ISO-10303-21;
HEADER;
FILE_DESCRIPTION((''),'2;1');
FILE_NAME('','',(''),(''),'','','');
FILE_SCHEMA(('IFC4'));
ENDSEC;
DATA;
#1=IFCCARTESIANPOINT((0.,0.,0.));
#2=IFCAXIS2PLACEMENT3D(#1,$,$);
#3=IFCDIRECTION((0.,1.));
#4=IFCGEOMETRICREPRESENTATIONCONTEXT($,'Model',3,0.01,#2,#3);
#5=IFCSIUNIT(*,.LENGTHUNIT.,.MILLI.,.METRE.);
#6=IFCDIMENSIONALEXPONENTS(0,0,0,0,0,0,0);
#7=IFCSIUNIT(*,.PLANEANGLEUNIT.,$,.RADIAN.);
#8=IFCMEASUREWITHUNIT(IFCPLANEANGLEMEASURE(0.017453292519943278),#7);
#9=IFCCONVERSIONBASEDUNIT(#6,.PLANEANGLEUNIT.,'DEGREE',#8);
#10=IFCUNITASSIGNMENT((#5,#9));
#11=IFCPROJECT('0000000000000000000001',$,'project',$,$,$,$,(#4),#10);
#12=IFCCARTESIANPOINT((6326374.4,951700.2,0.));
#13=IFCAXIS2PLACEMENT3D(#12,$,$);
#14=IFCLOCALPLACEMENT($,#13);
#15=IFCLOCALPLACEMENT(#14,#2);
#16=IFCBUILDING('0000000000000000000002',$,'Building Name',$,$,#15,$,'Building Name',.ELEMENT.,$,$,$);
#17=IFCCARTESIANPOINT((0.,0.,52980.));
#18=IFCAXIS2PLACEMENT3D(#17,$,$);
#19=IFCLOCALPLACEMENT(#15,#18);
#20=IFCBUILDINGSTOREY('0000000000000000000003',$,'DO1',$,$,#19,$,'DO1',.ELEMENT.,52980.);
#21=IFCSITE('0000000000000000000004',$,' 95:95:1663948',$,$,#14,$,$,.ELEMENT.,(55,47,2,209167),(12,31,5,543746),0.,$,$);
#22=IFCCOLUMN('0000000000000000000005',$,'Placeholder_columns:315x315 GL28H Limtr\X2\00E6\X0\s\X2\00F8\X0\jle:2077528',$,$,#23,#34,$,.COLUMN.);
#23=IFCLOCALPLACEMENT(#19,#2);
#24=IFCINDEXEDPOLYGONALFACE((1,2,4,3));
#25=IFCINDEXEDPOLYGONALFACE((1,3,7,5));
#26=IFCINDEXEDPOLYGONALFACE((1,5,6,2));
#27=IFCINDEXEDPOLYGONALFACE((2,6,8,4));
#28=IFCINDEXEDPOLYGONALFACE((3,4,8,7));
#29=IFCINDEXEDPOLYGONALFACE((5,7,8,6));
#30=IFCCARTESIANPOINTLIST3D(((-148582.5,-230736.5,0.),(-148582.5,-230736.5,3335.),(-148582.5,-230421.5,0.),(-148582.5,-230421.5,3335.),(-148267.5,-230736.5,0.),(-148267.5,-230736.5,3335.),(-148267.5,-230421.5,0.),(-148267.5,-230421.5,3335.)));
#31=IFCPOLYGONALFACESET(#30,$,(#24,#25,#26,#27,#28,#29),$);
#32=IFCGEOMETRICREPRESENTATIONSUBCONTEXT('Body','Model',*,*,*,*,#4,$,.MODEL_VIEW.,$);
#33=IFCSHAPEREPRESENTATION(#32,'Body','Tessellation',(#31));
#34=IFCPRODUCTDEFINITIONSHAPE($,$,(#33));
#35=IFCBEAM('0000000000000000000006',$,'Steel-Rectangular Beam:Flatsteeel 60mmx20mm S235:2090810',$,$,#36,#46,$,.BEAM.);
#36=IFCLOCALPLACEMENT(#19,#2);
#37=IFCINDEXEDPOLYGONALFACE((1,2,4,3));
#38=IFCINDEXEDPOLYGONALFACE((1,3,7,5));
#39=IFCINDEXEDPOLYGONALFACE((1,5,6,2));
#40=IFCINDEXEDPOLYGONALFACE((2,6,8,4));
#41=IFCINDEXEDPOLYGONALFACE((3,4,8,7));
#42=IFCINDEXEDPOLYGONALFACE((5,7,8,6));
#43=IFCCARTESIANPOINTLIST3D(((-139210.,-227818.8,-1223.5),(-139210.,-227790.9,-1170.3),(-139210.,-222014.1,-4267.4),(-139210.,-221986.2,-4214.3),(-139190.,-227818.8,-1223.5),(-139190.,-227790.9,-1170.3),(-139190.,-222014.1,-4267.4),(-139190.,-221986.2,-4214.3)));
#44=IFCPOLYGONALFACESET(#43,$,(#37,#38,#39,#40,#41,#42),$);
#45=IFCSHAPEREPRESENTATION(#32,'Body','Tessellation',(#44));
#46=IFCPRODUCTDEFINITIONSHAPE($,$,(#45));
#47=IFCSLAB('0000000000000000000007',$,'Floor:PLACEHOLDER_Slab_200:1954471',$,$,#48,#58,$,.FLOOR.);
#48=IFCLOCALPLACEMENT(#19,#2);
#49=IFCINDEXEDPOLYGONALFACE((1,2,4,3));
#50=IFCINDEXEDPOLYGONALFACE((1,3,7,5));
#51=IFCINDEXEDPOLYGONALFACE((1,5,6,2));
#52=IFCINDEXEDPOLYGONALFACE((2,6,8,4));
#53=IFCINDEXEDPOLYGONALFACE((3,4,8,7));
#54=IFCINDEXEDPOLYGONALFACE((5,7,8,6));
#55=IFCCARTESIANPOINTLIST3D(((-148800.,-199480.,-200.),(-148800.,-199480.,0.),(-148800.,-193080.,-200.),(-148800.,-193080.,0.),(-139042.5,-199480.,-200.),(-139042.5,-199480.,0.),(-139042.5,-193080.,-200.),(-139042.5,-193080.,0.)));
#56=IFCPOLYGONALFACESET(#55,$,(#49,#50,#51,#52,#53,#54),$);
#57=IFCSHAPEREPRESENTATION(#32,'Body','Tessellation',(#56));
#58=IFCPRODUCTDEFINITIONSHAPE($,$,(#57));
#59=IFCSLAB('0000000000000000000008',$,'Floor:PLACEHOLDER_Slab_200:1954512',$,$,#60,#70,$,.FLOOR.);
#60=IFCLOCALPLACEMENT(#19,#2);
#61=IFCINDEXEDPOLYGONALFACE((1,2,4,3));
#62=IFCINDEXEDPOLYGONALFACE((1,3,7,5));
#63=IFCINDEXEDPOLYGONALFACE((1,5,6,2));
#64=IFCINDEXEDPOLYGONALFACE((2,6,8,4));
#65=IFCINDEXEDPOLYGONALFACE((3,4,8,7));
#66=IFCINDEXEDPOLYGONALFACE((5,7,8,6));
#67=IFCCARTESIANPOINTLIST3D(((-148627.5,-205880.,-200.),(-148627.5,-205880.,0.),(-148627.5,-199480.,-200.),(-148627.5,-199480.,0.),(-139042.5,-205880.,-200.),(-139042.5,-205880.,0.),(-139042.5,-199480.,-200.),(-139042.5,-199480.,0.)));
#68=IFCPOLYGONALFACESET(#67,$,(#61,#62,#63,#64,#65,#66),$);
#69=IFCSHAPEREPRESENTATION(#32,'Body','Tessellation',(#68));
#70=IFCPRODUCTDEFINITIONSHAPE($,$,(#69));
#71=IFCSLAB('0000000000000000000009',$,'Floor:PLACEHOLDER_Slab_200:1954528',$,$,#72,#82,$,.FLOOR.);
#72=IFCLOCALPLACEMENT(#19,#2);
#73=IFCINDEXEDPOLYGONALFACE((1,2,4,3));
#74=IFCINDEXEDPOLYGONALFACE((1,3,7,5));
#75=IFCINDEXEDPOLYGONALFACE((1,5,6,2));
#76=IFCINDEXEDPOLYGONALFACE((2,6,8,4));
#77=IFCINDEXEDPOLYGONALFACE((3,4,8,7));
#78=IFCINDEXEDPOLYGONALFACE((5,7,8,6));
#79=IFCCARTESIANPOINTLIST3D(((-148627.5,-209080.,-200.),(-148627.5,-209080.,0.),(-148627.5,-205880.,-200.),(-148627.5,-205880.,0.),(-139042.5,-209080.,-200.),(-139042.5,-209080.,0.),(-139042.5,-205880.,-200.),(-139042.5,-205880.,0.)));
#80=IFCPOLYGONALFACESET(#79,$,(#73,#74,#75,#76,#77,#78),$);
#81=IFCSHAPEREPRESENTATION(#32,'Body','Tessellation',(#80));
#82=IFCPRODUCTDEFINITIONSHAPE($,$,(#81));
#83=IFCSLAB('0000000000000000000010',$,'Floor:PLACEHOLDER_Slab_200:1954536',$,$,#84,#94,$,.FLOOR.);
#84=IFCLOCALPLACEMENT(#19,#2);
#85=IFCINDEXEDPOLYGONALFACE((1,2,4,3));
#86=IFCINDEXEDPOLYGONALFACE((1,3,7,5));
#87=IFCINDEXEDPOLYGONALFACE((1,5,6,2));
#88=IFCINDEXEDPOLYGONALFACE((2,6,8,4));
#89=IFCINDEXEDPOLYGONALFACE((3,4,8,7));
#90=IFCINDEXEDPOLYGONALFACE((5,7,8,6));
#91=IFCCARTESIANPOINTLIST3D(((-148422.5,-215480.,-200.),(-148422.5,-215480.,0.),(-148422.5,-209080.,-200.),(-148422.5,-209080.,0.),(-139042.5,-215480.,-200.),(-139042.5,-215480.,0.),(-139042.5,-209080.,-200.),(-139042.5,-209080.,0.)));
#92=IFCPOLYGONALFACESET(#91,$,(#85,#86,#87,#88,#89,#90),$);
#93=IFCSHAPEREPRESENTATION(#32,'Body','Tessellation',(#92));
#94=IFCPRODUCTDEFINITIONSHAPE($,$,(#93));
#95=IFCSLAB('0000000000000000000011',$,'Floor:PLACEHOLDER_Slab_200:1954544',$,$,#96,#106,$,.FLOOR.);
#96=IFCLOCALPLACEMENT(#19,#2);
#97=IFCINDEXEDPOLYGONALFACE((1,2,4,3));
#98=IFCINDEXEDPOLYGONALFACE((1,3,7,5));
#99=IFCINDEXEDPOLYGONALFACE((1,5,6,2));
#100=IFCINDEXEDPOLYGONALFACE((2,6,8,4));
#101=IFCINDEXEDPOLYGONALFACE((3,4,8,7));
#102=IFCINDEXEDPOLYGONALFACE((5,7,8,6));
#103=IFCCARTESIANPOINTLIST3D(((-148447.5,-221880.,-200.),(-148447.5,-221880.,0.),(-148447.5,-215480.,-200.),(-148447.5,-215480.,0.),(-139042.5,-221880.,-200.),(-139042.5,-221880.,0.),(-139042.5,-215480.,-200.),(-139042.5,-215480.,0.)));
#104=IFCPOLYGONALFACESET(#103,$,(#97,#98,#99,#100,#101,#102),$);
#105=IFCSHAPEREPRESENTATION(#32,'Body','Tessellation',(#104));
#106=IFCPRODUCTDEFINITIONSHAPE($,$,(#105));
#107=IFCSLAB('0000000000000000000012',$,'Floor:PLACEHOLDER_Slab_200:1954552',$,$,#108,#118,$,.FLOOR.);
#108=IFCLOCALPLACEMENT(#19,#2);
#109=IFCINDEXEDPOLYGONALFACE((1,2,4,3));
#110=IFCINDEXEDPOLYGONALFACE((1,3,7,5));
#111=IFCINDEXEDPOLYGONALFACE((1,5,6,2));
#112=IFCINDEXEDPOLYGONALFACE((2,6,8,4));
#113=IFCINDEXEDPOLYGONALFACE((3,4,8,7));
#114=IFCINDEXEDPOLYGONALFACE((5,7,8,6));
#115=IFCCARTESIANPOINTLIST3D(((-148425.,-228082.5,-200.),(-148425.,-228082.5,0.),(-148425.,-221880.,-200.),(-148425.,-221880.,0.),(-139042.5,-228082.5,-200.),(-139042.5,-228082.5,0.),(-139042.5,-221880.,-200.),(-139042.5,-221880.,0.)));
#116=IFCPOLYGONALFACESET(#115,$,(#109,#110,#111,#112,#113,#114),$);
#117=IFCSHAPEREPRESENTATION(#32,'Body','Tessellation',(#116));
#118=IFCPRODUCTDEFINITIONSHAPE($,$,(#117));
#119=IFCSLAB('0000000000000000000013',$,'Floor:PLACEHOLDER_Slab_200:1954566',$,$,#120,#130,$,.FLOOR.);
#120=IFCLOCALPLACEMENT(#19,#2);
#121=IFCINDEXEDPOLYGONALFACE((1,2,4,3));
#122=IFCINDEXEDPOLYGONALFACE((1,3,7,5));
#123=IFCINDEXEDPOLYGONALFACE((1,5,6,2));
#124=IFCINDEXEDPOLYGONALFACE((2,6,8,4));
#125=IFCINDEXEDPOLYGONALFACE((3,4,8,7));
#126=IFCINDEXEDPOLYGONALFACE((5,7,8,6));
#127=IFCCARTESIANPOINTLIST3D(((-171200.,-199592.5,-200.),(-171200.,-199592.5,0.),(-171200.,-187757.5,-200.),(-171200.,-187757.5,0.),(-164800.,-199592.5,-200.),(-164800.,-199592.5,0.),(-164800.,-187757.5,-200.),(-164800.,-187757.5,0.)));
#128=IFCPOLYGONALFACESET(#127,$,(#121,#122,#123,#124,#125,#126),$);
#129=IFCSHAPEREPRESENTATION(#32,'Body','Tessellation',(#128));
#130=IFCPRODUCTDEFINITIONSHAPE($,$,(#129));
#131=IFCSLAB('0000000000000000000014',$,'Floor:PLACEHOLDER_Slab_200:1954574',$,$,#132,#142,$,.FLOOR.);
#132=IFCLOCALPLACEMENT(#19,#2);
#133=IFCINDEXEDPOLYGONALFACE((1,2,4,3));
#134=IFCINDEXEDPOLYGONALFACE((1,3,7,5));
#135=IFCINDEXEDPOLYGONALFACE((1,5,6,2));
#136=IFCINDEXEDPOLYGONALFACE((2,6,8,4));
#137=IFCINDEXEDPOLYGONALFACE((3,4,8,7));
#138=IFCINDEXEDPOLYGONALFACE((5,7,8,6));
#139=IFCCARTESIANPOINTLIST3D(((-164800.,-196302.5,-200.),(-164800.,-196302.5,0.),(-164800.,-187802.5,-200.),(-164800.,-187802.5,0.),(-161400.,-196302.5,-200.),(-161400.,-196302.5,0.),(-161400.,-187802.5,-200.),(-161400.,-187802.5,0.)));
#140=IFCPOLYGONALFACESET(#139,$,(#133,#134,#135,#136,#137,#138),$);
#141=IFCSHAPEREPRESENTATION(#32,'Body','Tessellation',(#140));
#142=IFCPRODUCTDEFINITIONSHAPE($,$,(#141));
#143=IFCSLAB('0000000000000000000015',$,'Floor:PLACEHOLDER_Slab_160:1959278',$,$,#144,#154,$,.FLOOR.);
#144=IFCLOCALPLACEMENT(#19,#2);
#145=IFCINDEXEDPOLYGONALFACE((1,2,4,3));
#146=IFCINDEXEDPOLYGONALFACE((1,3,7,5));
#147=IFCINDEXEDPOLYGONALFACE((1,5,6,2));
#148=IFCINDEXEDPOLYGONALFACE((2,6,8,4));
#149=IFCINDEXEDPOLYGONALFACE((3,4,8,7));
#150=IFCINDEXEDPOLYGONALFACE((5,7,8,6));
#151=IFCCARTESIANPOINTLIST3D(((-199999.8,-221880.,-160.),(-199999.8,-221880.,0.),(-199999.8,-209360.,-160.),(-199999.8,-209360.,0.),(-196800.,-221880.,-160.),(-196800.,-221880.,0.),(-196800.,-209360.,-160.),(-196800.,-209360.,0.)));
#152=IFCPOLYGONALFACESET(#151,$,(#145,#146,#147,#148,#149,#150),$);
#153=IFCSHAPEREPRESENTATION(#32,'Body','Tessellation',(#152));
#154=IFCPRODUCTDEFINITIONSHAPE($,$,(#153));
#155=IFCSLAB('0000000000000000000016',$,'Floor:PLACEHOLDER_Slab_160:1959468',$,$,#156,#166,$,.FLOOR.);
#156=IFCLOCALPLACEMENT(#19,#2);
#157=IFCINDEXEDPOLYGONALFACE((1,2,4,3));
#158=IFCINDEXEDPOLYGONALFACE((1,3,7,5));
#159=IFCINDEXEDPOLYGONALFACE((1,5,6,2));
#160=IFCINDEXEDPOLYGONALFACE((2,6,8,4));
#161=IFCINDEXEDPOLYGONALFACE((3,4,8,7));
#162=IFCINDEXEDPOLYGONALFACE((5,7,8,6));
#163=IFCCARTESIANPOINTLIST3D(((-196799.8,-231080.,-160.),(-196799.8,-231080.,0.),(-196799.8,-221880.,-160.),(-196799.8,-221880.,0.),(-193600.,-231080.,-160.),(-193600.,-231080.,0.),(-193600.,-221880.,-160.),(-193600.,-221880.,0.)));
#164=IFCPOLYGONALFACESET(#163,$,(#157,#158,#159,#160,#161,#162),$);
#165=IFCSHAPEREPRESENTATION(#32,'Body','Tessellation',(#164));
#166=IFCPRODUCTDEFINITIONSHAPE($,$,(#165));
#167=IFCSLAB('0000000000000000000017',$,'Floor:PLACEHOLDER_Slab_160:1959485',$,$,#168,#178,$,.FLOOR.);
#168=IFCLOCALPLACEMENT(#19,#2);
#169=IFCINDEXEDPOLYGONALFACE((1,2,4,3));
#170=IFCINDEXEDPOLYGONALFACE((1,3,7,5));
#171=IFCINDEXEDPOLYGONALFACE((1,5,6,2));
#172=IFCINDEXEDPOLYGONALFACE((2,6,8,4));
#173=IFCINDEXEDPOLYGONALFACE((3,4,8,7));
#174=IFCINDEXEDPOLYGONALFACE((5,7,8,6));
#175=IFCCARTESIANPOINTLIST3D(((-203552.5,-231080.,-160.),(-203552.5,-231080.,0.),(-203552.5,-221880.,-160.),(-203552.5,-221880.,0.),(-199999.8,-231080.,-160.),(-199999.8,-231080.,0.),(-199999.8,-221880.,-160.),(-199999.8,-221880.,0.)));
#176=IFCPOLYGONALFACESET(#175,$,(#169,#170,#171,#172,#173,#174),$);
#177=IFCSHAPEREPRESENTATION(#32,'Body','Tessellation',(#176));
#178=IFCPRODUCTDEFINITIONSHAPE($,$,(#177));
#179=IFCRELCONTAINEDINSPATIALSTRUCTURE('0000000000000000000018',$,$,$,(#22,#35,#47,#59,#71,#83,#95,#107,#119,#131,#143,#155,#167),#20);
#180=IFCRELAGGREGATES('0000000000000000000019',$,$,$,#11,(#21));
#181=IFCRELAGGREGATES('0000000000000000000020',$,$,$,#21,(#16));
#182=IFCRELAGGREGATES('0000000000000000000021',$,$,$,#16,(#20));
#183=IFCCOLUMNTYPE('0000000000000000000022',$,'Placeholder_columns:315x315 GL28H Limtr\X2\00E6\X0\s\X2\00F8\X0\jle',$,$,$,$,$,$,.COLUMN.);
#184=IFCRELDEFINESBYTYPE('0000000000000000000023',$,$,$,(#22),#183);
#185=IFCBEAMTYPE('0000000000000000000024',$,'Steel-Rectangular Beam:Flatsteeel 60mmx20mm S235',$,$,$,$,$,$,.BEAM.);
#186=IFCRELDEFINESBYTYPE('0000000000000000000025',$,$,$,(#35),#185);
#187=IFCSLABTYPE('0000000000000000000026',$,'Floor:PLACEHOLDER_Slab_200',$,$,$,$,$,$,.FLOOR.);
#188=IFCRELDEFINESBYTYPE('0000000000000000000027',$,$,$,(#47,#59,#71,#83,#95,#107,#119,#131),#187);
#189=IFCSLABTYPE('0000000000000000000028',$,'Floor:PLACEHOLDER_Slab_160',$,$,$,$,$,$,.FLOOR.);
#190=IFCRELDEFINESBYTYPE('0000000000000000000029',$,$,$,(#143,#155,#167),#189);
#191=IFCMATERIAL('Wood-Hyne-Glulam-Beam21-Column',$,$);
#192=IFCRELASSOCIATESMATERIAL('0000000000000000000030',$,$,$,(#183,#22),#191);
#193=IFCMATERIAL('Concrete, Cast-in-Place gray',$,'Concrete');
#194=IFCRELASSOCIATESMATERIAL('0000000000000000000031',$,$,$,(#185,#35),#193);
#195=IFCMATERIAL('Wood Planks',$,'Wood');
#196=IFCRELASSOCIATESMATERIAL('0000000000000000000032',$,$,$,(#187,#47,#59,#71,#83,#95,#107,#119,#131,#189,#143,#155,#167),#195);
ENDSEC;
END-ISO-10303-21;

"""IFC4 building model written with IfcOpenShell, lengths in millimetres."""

from ifc_helpers import new_model, entity, si_unit, converted_unit, direction, frame, origin, place, context, subcontext, project, spatial, indexed_curve, outline, extrude, source, transform, mapped, material, type_object, type_shapes, element, save


model = new_model("IFC4")

# Units and contexts
model_context = context("Model", 3, precision=0.01, world=origin(), true_north=direction((0.0, 1.0)))
body_context = subcontext(model_context, "Body", "Model", "MODEL_VIEW")
ifc_project = project(units=[si_unit("LENGTHUNIT", "METRE", prefix="MILLI"), converted_unit("PLANEANGLEUNIT", "DEGREE", entity("IfcPlaneAngleMeasure", 0.017453292519943278), si_unit("PLANEANGLEUNIT", "RADIAN"), dimensions=[0, 0, 0, 0, 0, 0, 0])], contexts=[model_context])

# Site, building, storey
site_placement = place(None, frame((6326374.4, 951700.2, 0.0)))
site = spatial("IfcSite", under=ifc_project, at=site_placement, Name=" 95:95:1663948", CompositionType="ELEMENT", RefLatitude=(55, 47, 2, 209167), RefLongitude=(12, 31, 5, 543746), RefElevation=0.0)
building_placement = place(site_placement, origin())
building = spatial("IfcBuilding", under=site, at=building_placement, Name="Building Name", LongName="Building Name", CompositionType="ELEMENT")
storey_placement = place(building_placement, frame((0.0, 0.0, 52980.0)))
storey = spatial("IfcBuildingStorey", under=building, at=storey_placement, Name="DO1", LongName="DO1", CompositionType="ELEMENT", Elevation=52980.0)

# Column
ifc_material_1 = material(Name="Wood-Hyne-Glulam-Beam21-Column")
column_type = type_object("IfcColumnType", Name="Placeholder_columns:315x315 GL28H Limtræsøjle", PredefinedType="COLUMN", material=ifc_material_1)
shared_shape_1 = source(origin(), body_context, "Body", "SweptSolid", [
    extrude(outline(indexed_curve([(-157.5, -157.5), (157.5, -157.5), (157.5, 157.5), (-157.5, 157.5), (-157.5, -157.5)], self_intersect=False)), frame((-148425.0, -230579.0, 52980.0), z_axis=(0.0, 0.0, 1.0), x_axis=(-1.0, 0.0, 0.0)), (0.0, 0.0, 1.0), 3335.0),
])
type_shapes(column_type, [shared_shape_1])
column_placement = place(storey_placement, frame((0.0, 0.0, -52980.0)))
element("IfcColumn", 1, at=column_placement, inside=storey, type_object=column_type, material=ifc_material_1, Name="Placeholder_columns:315x315 GL28H Limtræsøjle:2077528", PredefinedType="COLUMN", context=body_context, shape_type="MappedRepresentation", body=[
    mapped(shared_shape_1, transform((0.0, 0.0, 0.0), scale=1.0)),
])

# Beam
ifc_material_2 = material(Name="Concrete, Cast-in-Place gray", Category="Concrete")
beam_type_1 = type_object("IfcBeamType", Name="Steel-Rectangular Beam:Flatsteeel 60mmx20mm S235", PredefinedType="BEAM", material=ifc_material_2)
shared_shape_2 = source(origin(), body_context, "Body", "SweptSolid", [
    extrude(outline(indexed_curve([(-30.0, -10.0), (30.0, -10.0), (30.0, 10.0), (-30.0, 10.0), (-30.0, -10.0)], self_intersect=False)), frame((-139200.0, -227804.8, 51783.1), z_axis=(0.0, 0.885616, -0.464418), x_axis=(0.0, 0.464418, 0.885616)), (0.0, 0.0, 1.0), 6554.4),
])
type_shapes(beam_type_1, [shared_shape_2])
beam_1_placement = place(storey_placement, frame((0.0, 0.0, -52980.0)))
element("IfcBeam", 2, at=beam_1_placement, inside=storey, type_object=beam_type_1, material=ifc_material_2, Name="Steel-Rectangular Beam:Flatsteeel 60mmx20mm S235:2090810", PredefinedType="BEAM", context=body_context, shape_type="MappedRepresentation", body=[
    mapped(shared_shape_2, transform((0.0, 0.0, 0.0), scale=1.0)),
])

# Slabs
ifc_material_3 = material(Name="Wood Planks", Category="Wood")
slab_type_1 = type_object("IfcSlabType", Name="Floor:PLACEHOLDER_Slab_200", PredefinedType="FLOOR", material=ifc_material_3)
slab_1_placement = place(storey_placement, origin())
element("IfcSlab", 3, at=slab_1_placement, inside=storey, type_object=slab_type_1, material=ifc_material_3, Name="Floor:PLACEHOLDER_Slab_200:1954471", PredefinedType="FLOOR", context=body_context, shape_type="SweptSolid", body=[
    extrude(outline(indexed_curve([(-3200.0, -4878.7), (3200.0, -4878.7), (3200.0, 4878.7), (-3200.0, 4878.7), (-3200.0, -4878.7)], self_intersect=False)), frame((-143921.2, -196280.0, 0.0), z_axis=(0.0, 0.0, -1.0), x_axis=(0.0, 1.0, 0.0)), (0.0, 0.0, 1.0), 200.0),
])
slab_2_placement = place(storey_placement, origin())
element("IfcSlab", 4, at=slab_2_placement, inside=storey, type_object=slab_type_1, material=ifc_material_3, Name="Floor:PLACEHOLDER_Slab_200:1954512", PredefinedType="FLOOR", context=body_context, shape_type="SweptSolid", body=[
    extrude(outline(indexed_curve([(-3200.0, -4792.5), (3200.0, -4792.5), (3200.0, 4792.5), (-3200.0, 4792.5), (-3200.0, -4792.5)], self_intersect=False)), frame((-143835.0, -202680.0, 0.0), z_axis=(0.0, 0.0, -1.0), x_axis=(0.0, 1.0, 0.0)), (0.0, 0.0, 1.0), 200.0),
])
slab_3_placement = place(storey_placement, origin())
element("IfcSlab", 5, at=slab_3_placement, inside=storey, type_object=slab_type_1, material=ifc_material_3, Name="Floor:PLACEHOLDER_Slab_200:1954528", PredefinedType="FLOOR", context=body_context, shape_type="SweptSolid", body=[
    extrude(outline(indexed_curve([(-1600.0, -4792.5), (1600.0, -4792.5), (1600.0, 4792.5), (-1600.0, 4792.5), (-1600.0, -4792.5)], self_intersect=False)), frame((-143835.0, -207480.0, 0.0), z_axis=(0.0, 0.0, -1.0), x_axis=(0.0, 1.0, 0.0)), (0.0, 0.0, 1.0), 200.0),
])
slab_4_placement = place(storey_placement, origin())
element("IfcSlab", 6, at=slab_4_placement, inside=storey, type_object=slab_type_1, material=ifc_material_3, Name="Floor:PLACEHOLDER_Slab_200:1954536", PredefinedType="FLOOR", context=body_context, shape_type="SweptSolid", body=[
    extrude(outline(indexed_curve([(-4690.0, -3200.0), (4690.0, -3200.0), (4690.0, 3200.0), (-4690.0, 3200.0), (-4690.0, -3200.0)], self_intersect=False)), frame((-143732.5, -212280.0, 0.0), z_axis=(0.0, 0.0, -1.0), x_axis=(1.0, 0.0, 0.0)), (0.0, 0.0, 1.0), 200.0),
])
slab_5_placement = place(storey_placement, origin())
element("IfcSlab", 7, at=slab_5_placement, inside=storey, type_object=slab_type_1, material=ifc_material_3, Name="Floor:PLACEHOLDER_Slab_200:1954544", PredefinedType="FLOOR", context=body_context, shape_type="SweptSolid", body=[
    extrude(outline(indexed_curve([(-3200.0, -4702.5), (3200.0, -4702.5), (3200.0, 4702.5), (-3200.0, 4702.5), (-3200.0, -4702.5)], self_intersect=False)), frame((-143745.0, -218680.0, 0.0), z_axis=(0.0, 0.0, -1.0), x_axis=(0.0, 1.0, 0.0)), (0.0, 0.0, 1.0), 200.0),
])
slab_6_placement = place(storey_placement, origin())
element("IfcSlab", 8, at=slab_6_placement, inside=storey, type_object=slab_type_1, material=ifc_material_3, Name="Floor:PLACEHOLDER_Slab_200:1954552", PredefinedType="FLOOR", context=body_context, shape_type="SweptSolid", body=[
    extrude(outline(indexed_curve([(-3101.3, -4691.2), (3101.3, -4691.2), (3101.3, 4691.3), (-3101.3, 4691.3), (-3101.3, -4691.2)], self_intersect=False)), frame((-143733.7, -224981.3, 0.0), z_axis=(0.0, 0.0, -1.0), x_axis=(0.0, 1.0, 0.0)), (0.0, 0.0, 1.0), 200.0),
])
slab_7_placement = place(storey_placement, origin())
element("IfcSlab", 9, at=slab_7_placement, inside=storey, type_object=slab_type_1, material=ifc_material_3, Name="Floor:PLACEHOLDER_Slab_200:1954566", PredefinedType="FLOOR", context=body_context, shape_type="SweptSolid", body=[
    extrude(outline(indexed_curve([(-5917.5, -3200.0), (5917.5, -3200.0), (5917.5, 3200.0), (-5917.5, 3200.0), (-5917.5, -3200.0)], self_intersect=False)), frame((-168000.0, -193675.0, 0.0), z_axis=(0.0, 0.0, -1.0), x_axis=(0.0, 1.0, 0.0)), (0.0, 0.0, 1.0), 200.0),
])
slab_8_placement = place(storey_placement, origin())
element("IfcSlab", 10, at=slab_8_placement, inside=storey, type_object=slab_type_1, material=ifc_material_3, Name="Floor:PLACEHOLDER_Slab_200:1954574", PredefinedType="FLOOR", context=body_context, shape_type="SweptSolid", body=[
    extrude(outline(indexed_curve([(-4250.0, -1700.0), (4250.0, -1700.0), (4250.0, 1700.0), (-4250.0, 1700.0), (-4250.0, -1700.0)], self_intersect=False)), frame((-163100.0, -192052.5, 0.0), z_axis=(0.0, 0.0, -1.0), x_axis=(0.0, 1.0, 0.0)), (0.0, 0.0, 1.0), 200.0),
])
slab_type_2 = type_object("IfcSlabType", Name="Floor:PLACEHOLDER_Slab_160", PredefinedType="FLOOR", material=ifc_material_3)
slab_9_placement = place(storey_placement, origin())
element("IfcSlab", 11, at=slab_9_placement, inside=storey, type_object=slab_type_2, material=ifc_material_3, Name="Floor:PLACEHOLDER_Slab_160:1959278", PredefinedType="FLOOR", context=body_context, shape_type="SweptSolid", body=[
    extrude(outline(indexed_curve([(-6260.0, -1599.9), (6260.0, -1599.9), (6260.0, 1599.9), (-6260.0, 1599.9), (-6260.0, -1599.9)], self_intersect=False)), frame((-198399.9, -215620.0, 0.0), z_axis=(0.0, 0.0, -1.0), x_axis=(0.0, 1.0, 0.0)), (0.0, 0.0, 1.0), 160.0),
])
slab_10_placement = place(storey_placement, origin())
element("IfcSlab", 12, at=slab_10_placement, inside=storey, type_object=slab_type_2, material=ifc_material_3, Name="Floor:PLACEHOLDER_Slab_160:1959468", PredefinedType="FLOOR", context=body_context, shape_type="SweptSolid", body=[
    extrude(outline(indexed_curve([(-4600.0, -1599.9), (4600.0, -1599.9), (4600.0, 1599.9), (-4600.0, 1599.9), (-4600.0, -1599.9)], self_intersect=False)), frame((-195199.9, -226480.0, 0.0), z_axis=(0.0, 0.0, -1.0), x_axis=(0.0, 1.0, 0.0)), (0.0, 0.0, 1.0), 160.0),
])
slab_11_placement = place(storey_placement, origin())
element("IfcSlab", 13, at=slab_11_placement, inside=storey, type_object=slab_type_2, material=ifc_material_3, Name="Floor:PLACEHOLDER_Slab_160:1959485", PredefinedType="FLOOR", context=body_context, shape_type="SweptSolid", body=[
    extrude(outline(indexed_curve([(-4600.0, -1776.3), (4600.0, -1776.3), (4600.0, 1776.3), (-4600.0, 1776.3), (-4600.0, -1776.3)], self_intersect=False)), frame((-201776.2, -226480.0, 0.0), z_axis=(0.0, 0.0, -1.0), x_axis=(0.0, 1.0, 0.0)), (0.0, 0.0, 1.0), 160.0),
])

save(model, "model.ifc")
